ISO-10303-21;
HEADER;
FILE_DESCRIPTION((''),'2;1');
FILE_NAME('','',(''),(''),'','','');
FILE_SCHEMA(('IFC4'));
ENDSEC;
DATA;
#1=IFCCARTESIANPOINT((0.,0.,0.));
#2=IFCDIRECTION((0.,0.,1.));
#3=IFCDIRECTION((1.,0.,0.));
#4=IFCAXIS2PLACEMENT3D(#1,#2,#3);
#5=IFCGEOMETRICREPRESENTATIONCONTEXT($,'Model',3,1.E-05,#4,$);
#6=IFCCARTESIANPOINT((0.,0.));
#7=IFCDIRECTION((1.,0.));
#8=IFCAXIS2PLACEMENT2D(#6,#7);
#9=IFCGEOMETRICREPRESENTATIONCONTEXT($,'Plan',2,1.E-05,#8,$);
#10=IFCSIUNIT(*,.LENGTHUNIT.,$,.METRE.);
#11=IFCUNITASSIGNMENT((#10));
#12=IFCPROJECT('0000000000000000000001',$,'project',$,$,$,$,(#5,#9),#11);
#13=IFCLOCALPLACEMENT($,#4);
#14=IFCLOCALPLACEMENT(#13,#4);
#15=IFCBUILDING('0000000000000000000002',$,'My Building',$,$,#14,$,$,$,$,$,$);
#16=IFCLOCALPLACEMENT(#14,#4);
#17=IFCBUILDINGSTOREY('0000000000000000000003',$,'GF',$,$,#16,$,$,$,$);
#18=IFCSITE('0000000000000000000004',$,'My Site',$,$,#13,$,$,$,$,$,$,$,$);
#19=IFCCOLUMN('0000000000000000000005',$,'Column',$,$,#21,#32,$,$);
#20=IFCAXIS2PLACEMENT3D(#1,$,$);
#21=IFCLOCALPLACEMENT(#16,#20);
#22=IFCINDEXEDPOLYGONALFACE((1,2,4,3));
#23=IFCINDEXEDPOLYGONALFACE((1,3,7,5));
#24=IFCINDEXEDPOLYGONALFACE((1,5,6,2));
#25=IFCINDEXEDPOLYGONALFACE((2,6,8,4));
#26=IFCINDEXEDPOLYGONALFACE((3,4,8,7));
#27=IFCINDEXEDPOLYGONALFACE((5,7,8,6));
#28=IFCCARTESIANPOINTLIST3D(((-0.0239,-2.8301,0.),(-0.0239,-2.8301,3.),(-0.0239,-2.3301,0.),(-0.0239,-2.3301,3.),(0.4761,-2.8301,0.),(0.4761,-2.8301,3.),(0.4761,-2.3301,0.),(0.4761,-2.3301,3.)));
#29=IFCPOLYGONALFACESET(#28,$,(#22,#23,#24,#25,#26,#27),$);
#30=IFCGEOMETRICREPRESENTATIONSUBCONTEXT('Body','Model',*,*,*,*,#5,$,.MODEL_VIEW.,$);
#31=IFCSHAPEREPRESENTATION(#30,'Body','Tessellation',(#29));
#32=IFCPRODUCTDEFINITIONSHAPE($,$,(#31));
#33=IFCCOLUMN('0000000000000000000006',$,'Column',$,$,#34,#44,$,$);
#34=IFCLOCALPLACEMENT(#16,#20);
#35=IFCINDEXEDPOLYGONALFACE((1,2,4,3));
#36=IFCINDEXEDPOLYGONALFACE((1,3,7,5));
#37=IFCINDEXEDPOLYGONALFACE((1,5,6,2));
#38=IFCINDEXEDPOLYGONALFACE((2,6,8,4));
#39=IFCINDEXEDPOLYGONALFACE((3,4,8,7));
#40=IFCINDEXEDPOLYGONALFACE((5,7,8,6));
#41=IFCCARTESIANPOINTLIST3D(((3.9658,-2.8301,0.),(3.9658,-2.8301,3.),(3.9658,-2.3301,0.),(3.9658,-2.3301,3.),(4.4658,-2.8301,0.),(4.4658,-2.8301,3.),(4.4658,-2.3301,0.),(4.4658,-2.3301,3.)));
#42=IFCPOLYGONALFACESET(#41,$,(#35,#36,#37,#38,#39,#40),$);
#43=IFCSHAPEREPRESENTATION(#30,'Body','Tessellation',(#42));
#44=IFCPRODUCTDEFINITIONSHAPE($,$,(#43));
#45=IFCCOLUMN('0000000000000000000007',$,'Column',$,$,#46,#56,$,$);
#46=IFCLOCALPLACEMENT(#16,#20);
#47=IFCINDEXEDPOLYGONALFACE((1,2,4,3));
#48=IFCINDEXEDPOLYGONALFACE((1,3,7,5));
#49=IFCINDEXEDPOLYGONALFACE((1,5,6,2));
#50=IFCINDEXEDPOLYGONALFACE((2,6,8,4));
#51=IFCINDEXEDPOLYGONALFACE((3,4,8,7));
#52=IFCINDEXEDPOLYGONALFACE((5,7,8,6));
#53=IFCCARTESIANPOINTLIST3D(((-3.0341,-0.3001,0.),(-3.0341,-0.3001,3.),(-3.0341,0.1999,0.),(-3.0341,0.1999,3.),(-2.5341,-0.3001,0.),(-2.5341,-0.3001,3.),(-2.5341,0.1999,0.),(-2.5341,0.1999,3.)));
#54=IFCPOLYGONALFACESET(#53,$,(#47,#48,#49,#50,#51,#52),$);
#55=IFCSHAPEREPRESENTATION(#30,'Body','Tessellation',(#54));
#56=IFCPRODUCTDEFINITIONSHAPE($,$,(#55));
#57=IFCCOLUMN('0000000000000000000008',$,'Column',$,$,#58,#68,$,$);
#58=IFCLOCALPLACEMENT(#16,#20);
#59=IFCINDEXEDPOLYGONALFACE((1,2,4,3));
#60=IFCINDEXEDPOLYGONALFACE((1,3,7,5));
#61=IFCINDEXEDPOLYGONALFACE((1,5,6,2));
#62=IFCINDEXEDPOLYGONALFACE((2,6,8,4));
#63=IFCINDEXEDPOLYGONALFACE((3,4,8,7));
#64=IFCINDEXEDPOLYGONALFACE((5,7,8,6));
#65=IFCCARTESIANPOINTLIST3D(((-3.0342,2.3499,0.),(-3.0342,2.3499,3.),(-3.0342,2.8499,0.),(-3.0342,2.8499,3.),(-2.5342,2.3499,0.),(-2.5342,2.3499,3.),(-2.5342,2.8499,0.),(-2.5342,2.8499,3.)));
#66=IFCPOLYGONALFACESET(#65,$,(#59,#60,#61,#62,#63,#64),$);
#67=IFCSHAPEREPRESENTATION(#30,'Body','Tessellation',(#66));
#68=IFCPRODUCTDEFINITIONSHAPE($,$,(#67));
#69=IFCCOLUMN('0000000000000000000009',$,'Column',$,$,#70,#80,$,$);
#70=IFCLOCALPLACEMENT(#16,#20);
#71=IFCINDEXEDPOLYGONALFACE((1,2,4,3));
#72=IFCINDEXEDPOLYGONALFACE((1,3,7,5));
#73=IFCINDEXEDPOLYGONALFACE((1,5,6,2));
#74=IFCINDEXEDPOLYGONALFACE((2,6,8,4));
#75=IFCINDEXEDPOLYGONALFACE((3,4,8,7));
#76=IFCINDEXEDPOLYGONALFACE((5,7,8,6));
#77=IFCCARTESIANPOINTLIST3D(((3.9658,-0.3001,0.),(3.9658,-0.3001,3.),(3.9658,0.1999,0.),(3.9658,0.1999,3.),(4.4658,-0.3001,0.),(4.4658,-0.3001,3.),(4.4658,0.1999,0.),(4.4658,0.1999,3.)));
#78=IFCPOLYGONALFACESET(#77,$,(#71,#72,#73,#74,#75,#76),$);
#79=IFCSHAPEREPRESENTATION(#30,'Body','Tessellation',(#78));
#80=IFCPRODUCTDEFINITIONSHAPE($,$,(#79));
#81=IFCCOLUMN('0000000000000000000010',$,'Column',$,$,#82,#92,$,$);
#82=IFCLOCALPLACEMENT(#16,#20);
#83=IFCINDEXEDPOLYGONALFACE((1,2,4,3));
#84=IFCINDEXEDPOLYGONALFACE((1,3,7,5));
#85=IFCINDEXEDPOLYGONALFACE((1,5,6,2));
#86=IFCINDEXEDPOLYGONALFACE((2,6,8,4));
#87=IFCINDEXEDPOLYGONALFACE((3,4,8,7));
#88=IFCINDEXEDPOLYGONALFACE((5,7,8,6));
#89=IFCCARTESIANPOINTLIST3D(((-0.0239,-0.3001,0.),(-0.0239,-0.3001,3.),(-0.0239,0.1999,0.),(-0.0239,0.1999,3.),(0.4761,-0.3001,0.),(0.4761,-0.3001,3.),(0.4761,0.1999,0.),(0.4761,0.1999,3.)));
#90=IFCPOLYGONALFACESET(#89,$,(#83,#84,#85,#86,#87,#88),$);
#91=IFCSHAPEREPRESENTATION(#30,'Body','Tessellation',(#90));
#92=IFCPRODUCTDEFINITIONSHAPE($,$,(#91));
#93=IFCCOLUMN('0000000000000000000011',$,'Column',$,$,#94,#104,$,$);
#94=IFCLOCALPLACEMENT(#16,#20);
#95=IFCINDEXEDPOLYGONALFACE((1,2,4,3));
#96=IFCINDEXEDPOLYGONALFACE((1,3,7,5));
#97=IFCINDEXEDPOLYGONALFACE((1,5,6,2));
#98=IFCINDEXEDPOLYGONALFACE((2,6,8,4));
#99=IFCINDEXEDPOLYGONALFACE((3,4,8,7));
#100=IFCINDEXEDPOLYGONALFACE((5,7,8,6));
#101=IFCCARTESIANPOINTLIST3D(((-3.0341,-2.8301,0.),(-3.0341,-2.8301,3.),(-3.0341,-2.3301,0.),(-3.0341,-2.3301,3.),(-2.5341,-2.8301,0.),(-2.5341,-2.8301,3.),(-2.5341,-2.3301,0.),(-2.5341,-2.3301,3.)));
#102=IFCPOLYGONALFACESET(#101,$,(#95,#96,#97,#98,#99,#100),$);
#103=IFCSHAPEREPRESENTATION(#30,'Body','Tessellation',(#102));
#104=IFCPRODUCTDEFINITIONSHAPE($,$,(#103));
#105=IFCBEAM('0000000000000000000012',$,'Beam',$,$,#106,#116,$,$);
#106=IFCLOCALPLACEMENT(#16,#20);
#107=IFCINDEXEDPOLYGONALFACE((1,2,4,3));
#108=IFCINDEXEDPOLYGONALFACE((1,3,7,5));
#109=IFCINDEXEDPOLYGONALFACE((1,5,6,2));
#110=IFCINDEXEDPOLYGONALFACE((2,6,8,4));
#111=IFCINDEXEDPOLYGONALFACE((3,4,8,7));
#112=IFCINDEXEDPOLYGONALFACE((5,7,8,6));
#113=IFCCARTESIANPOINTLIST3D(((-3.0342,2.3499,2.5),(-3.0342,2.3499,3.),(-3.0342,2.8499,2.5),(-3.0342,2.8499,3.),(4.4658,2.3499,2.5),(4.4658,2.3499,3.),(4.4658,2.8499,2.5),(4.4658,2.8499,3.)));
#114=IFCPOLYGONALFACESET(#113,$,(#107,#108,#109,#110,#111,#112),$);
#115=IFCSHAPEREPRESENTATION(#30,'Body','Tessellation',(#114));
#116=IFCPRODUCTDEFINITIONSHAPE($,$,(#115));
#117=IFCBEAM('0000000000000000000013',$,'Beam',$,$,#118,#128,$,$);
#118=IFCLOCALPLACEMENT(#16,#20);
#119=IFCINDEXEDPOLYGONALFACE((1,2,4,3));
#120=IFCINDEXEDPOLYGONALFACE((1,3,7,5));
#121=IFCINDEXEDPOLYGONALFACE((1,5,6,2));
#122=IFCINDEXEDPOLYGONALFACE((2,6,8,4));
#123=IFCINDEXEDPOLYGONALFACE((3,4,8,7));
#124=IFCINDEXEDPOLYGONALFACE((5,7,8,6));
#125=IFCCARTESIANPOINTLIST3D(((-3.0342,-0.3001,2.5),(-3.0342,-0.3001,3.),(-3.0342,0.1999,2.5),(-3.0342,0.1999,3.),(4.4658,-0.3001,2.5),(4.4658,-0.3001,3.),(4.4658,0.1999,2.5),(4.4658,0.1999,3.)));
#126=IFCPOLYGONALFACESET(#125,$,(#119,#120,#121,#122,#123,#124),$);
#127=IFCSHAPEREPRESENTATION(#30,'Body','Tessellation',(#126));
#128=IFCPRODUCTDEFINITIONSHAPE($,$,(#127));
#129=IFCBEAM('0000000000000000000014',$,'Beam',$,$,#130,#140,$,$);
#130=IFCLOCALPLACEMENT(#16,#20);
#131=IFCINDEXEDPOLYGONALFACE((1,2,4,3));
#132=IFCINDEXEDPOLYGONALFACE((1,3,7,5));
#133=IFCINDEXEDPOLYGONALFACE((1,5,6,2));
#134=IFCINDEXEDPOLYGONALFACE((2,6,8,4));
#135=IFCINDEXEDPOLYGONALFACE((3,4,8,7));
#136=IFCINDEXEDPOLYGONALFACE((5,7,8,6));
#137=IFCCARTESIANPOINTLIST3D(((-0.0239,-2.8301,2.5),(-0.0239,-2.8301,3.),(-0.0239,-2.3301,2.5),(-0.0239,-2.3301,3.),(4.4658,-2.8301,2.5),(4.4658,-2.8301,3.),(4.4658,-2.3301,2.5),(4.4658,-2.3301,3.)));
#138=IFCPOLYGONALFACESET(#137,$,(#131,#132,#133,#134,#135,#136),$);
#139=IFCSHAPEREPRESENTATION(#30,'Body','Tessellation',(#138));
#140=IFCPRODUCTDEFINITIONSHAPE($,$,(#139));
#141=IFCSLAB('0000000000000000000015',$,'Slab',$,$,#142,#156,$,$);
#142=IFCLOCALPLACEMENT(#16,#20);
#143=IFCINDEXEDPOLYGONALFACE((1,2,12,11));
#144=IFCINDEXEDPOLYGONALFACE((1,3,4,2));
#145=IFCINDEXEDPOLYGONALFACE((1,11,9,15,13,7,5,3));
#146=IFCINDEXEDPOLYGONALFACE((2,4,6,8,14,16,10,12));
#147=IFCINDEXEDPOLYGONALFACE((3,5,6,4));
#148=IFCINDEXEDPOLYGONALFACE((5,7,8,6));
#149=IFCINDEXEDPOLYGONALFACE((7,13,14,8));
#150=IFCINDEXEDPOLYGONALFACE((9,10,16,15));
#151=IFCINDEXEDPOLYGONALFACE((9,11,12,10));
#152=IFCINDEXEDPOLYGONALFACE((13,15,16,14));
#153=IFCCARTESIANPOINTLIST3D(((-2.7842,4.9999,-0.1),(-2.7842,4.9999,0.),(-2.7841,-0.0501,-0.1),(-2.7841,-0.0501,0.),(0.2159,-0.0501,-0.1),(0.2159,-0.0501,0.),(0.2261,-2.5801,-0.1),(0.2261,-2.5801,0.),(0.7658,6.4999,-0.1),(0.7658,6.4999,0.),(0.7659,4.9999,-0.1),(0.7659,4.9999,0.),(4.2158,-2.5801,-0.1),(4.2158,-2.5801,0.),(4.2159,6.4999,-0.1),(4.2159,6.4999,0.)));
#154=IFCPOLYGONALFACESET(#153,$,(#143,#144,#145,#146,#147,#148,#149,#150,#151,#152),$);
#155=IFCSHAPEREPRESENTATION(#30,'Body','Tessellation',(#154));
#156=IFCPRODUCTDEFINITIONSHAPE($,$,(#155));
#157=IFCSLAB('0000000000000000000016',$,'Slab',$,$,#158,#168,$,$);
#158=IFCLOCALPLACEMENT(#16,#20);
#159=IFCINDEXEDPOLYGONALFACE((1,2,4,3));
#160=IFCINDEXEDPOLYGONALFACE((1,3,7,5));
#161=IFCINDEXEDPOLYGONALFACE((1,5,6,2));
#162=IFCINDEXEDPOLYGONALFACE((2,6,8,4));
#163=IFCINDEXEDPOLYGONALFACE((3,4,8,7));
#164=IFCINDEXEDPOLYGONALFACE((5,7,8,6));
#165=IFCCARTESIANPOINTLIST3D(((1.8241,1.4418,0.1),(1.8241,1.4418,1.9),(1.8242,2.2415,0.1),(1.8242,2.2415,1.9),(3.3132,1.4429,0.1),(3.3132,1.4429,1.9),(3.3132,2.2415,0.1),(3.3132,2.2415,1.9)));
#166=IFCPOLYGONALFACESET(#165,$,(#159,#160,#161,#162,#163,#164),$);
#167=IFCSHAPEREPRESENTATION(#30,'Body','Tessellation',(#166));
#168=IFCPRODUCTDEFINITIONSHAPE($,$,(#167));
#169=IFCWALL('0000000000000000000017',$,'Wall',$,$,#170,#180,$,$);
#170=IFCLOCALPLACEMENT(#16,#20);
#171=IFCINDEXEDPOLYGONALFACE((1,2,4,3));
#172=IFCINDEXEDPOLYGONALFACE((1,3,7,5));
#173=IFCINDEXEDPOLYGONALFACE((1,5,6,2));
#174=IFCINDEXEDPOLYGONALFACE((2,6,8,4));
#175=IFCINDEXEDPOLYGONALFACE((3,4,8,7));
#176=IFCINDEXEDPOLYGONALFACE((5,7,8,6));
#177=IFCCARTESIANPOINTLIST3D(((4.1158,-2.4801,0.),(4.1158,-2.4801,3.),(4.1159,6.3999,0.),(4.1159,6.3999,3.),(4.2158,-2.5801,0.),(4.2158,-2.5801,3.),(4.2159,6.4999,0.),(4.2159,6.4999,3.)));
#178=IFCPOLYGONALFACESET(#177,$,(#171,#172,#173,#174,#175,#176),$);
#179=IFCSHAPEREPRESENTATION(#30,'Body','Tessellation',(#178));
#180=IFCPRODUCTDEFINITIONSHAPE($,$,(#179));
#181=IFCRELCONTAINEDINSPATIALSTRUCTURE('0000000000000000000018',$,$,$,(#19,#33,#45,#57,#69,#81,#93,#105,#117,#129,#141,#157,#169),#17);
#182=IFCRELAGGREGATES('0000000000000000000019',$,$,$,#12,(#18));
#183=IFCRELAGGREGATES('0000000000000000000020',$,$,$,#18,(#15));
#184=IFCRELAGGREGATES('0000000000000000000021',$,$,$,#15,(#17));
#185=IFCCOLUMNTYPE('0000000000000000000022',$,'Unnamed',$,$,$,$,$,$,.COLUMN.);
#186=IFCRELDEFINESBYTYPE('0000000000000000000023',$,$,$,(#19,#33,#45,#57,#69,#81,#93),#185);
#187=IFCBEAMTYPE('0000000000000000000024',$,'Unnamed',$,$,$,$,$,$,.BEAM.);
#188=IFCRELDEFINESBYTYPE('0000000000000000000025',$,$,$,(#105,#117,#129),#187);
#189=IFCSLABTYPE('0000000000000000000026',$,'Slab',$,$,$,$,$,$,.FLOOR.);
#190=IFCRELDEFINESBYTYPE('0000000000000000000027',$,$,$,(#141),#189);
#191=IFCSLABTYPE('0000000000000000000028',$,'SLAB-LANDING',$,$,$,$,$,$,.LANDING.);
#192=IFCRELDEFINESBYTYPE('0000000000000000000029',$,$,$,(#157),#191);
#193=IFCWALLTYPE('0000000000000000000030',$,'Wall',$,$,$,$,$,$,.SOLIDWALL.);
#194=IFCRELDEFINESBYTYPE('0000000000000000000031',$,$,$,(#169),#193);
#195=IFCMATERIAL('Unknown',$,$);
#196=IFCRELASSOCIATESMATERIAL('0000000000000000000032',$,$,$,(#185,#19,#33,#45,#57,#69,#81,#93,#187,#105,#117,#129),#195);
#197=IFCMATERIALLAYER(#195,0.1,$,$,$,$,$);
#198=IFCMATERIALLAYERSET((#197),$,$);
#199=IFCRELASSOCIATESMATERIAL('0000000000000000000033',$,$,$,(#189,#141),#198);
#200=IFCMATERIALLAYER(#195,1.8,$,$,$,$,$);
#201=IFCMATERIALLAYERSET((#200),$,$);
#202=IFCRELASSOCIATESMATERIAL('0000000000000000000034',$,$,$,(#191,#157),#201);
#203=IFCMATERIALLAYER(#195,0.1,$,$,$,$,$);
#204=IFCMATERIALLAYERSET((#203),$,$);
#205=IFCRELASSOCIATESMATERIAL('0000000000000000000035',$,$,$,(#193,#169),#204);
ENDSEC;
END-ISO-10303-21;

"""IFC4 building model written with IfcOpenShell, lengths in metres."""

from ifc_helpers import new_model, si_unit, frame, origin_with_axes, origin_2d_with_axis, place, context, subcontext, project, spatial, line, indexed_curve, rectangle, outline, extrude, material, layer, layer_set, layer_usage, material_profile, profile_set, profile_usage, type_object, element, save


model = new_model("IFC4")

# Units and contexts
model_context = context("Model", 3, precision=1e-05, world=origin_with_axes())
plan_context = context("Plan", 2, precision=1e-05, world=origin_2d_with_axis())
body_context_1 = subcontext(model_context, "Body", "Model", "MODEL_VIEW")
ifc_project = project(units=[si_unit("LENGTHUNIT", "METRE")], contexts=[model_context, plan_context])

# Site, building, storey
site_placement = place(None, origin_with_axes())
site = spatial("IfcSite", under=ifc_project, at=site_placement, Name="My Site")
building_placement = place(site_placement, origin_with_axes())
building = spatial("IfcBuilding", under=site, at=building_placement, Name="My Building")
storey_placement = place(building_placement, origin_with_axes())
storey = spatial("IfcBuildingStorey", under=building, at=storey_placement, Name="GF")

# Columns
ifc_material = material(Name="Unknown")
ifc_material_profile_1 = material_profile(ifc_material, rectangle(XDim=0.5, YDim=0.5))
ifc_profile_set_1 = profile_set([ifc_material_profile_1])
ifc_profile_usage_1 = profile_usage(ifc_profile_set_1, cardinal=5)
column_type = type_object("IfcColumnType", Name="Unnamed", PredefinedType="COLUMN", material=ifc_profile_set_1)
column_1_placement = place(storey_placement, frame((0.2261, -2.5801, 0.0), z_axis=(0.0, 0.0, 1.0), x_axis=(1.0, 0.0, 0.0)))
element("IfcColumn", 1, at=column_1_placement, inside=storey, type_object=column_type, material=ifc_profile_usage_1, Name="Column", context=body_context_1, shape_type="SweptSolid", body=[
    extrude(rectangle(XDim=0.5, YDim=0.5), origin_with_axes(), (0.0, 0.0, 1.0), 3.0),
])
ifc_profile_usage_2 = profile_usage(ifc_profile_set_1, cardinal=5)
column_2_placement = place(storey_placement, frame((4.2158, -2.5801, 0.0), z_axis=(0.0, 0.0, 1.0), x_axis=(1.0, 0.0, 0.0)))
element("IfcColumn", 2, at=column_2_placement, inside=storey, type_object=column_type, material=ifc_profile_usage_2, Name="Column", context=body_context_1, shape_type="SweptSolid", body=[
    extrude(rectangle(XDim=0.5, YDim=0.5), origin_with_axes(), (0.0, 0.0, 1.0), 3.0),
])
ifc_profile_usage_3 = profile_usage(ifc_profile_set_1, cardinal=5)
column_3_placement = place(storey_placement, frame((-2.7841, -0.0501, 0.0), z_axis=(0.0, 0.0, 1.0), x_axis=(1.0, 0.0, 0.0)))
element("IfcColumn", 3, at=column_3_placement, inside=storey, type_object=column_type, material=ifc_profile_usage_3, Name="Column", context=body_context_1, shape_type="SweptSolid", body=[
    extrude(rectangle(XDim=0.5, YDim=0.5), origin_with_axes(), (0.0, 0.0, 1.0), 3.0),
])
ifc_profile_usage_4 = profile_usage(ifc_profile_set_1, cardinal=5)
column_4_placement = place(storey_placement, frame((-2.7842, 2.5999, 0.0), z_axis=(0.0, 0.0, 1.0), x_axis=(1.0, 0.0, 0.0)))
element("IfcColumn", 4, at=column_4_placement, inside=storey, type_object=column_type, material=ifc_profile_usage_4, Name="Column", context=body_context_1, shape_type="SweptSolid", body=[
    extrude(rectangle(XDim=0.5, YDim=0.5), origin_with_axes(), (0.0, 0.0, 1.0), 3.0),
])
ifc_profile_usage_5 = profile_usage(ifc_profile_set_1, cardinal=5)
column_5_placement = place(storey_placement, frame((4.2158, -0.0501, 0.0), z_axis=(0.0, 0.0, 1.0), x_axis=(1.0, 0.0, 0.0)))
element("IfcColumn", 5, at=column_5_placement, inside=storey, type_object=column_type, material=ifc_profile_usage_5, Name="Column", context=body_context_1, shape_type="SweptSolid", body=[
    extrude(rectangle(XDim=0.5, YDim=0.5), origin_with_axes(), (0.0, 0.0, 1.0), 3.0),
])
ifc_profile_usage_6 = profile_usage(ifc_profile_set_1, cardinal=5)
column_6_placement = place(storey_placement, frame((0.2261, -0.0501, 0.0), z_axis=(0.0, 0.0, 1.0), x_axis=(1.0, 0.0, 0.0)))
element("IfcColumn", 6, at=column_6_placement, inside=storey, type_object=column_type, material=ifc_profile_usage_6, Name="Column", context=body_context_1, shape_type="SweptSolid", body=[
    extrude(rectangle(XDim=0.5, YDim=0.5), origin_with_axes(), (0.0, 0.0, 1.0), 3.0),
])
ifc_profile_usage_7 = profile_usage(ifc_profile_set_1, cardinal=5)
column_7_placement = place(storey_placement, frame((-2.7841, -2.5801, 0.0), z_axis=(0.0, 0.0, 1.0), x_axis=(1.0, 0.0, 0.0)))
element("IfcColumn", 7, at=column_7_placement, inside=storey, type_object=column_type, material=ifc_profile_usage_7, Name="Column", context=body_context_1, shape_type="SweptSolid", body=[
    extrude(rectangle(XDim=0.5, YDim=0.5), origin_with_axes(), (0.0, 0.0, 1.0), 3.0),
])

# Beams
ifc_material_profile_2 = material_profile(ifc_material, rectangle(XDim=0.5, YDim=0.5))
ifc_profile_set_2 = profile_set([ifc_material_profile_2])
ifc_profile_usage_8 = profile_usage(ifc_profile_set_2, cardinal=7)
beam_type = type_object("IfcBeamType", Name="Unnamed", PredefinedType="BEAM", material=ifc_profile_set_2)
beam_1_placement = place(storey_placement, frame((4.4658, 2.3499, 3.0), z_axis=(-1.0, 0.0, 0.0), x_axis=(0.0, -1.0, 0.0)))
element("IfcBeam", 8, at=beam_1_placement, inside=storey, type_object=beam_type, material=ifc_profile_usage_8, Name="Beam", context=body_context_1, shape_type="SweptSolid", body=[
    extrude(rectangle(XDim=0.5, YDim=0.5), frame((-0.25, -0.25, 0.0), z_axis=(0.0, 0.0, 1.0), x_axis=(1.0, 0.0, 0.0)), (0.0, 0.0, 1.0), 7.5),
])
ifc_profile_usage_9 = profile_usage(ifc_profile_set_2, cardinal=7)
beam_2_placement = place(storey_placement, frame((4.4658, -0.3001, 3.0), z_axis=(-1.0, 0.0, 0.0), x_axis=(0.0, -1.0, 0.0)))
element("IfcBeam", 9, at=beam_2_placement, inside=storey, type_object=beam_type, material=ifc_profile_usage_9, Name="Beam", context=body_context_1, shape_type="SweptSolid", body=[
    extrude(rectangle(XDim=0.5, YDim=0.5), frame((-0.25, -0.25, 0.0), z_axis=(0.0, 0.0, 1.0), x_axis=(1.0, 0.0, 0.0)), (0.0, 0.0, 1.0), 7.5),
])
ifc_profile_usage_10 = profile_usage(ifc_profile_set_2, cardinal=7)
beam_3_placement = place(storey_placement, frame((4.4658, -2.8301, 3.0), z_axis=(-1.0, -0.000001, 0.0), x_axis=(0.000001, -1.0, 0.0)))
element("IfcBeam", 10, at=beam_3_placement, inside=storey, type_object=beam_type, material=ifc_profile_usage_10, Name="Beam", context=body_context_1, shape_type="SweptSolid", body=[
    extrude(rectangle(XDim=0.5, YDim=0.5), frame((-0.25, -0.25, 0.0), z_axis=(0.0, 0.0, 1.0), x_axis=(1.0, 0.0, 0.0)), (0.0, 0.0, 1.0), 4.4897),
])

# Slabs
ifc_layer_1 = layer(ifc_material, 0.1)
ifc_layer_set_1 = layer_set([ifc_layer_1])
ifc_layer_usage_1 = layer_usage(ifc_layer_set_1, "AXIS3", "POSITIVE", -0.1)
slab_type_1 = type_object("IfcSlabType", Name="Slab", PredefinedType="FLOOR", material=ifc_layer_set_1)
slab_1_placement = place(storey_placement, frame((0.2261, -2.5801, 0.0), z_axis=(0.0, 0.0, 1.0), x_axis=(1.0, 0.0, 0.0)))
element("IfcSlab", 11, at=slab_1_placement, inside=storey, type_object=slab_type_1, material=ifc_layer_usage_1, Name="Slab", context=body_context_1, shape_type="SweptSolid", body=[
    extrude(outline(indexed_curve([(0.0, 0.0), (3.9897, 0.0), (3.9897, 9.08), (0.5397, 9.08), (0.5397, 7.58), (-3.0103, 7.58), (-3.0103, 2.53), (-0.0103, 2.53), (0.0, 0.0)])), frame((0.0, 0.0, -0.1), z_axis=(0.0, 0.0, 1.0), x_axis=(1.0, 0.0, 0.0)), (0.0, 0.0, 1.0), 0.1),
])
ifc_layer_2 = layer(ifc_material, 1.8)
ifc_layer_set_2 = layer_set([ifc_layer_2])
slab_type_2 = type_object("IfcSlabType", Name="SLAB-LANDING", PredefinedType="LANDING", material=ifc_layer_set_2)
ifc_layer_usage_2 = layer_usage(ifc_layer_set_2, "AXIS3", "POSITIVE", -1.8)
slab_2_placement = place(storey_placement, frame((1.8241, 1.4418, 1.9), z_axis=(0.0, 0.0, 1.0), x_axis=(1.0, 0.0, 0.0)))
element("IfcSlab", 12, at=slab_2_placement, inside=storey, type_object=slab_type_2, material=ifc_layer_usage_2, Name="Slab", context=body_context_1, shape_type="SweptSolid", body=[
    extrude(outline(indexed_curve([(0.0, 0.0), (1.489, 0.0011), (1.489, 0.7997), (0.0, 0.7997), (0.0, 0.0)])), frame((0.0, 0.0, -1.8), z_axis=(0.0, 0.0, 1.0), x_axis=(1.0, 0.0, 0.0)), (0.0, 0.0, 1.0), 1.8),
])

# Shared definitions
ifc_layer_3 = layer(ifc_material, 0.1)
ifc_layer_set_3 = layer_set([ifc_layer_3])
wall_type = type_object("IfcWallType", Name="Wall", PredefinedType="SOLIDWALL", material=ifc_layer_set_3)

# Wall
ifc_layer_usage_3 = layer_usage(ifc_layer_set_3, "AXIS2", "POSITIVE", 0.0)
wall_1_placement = place(storey_placement, frame((4.2158, -2.5801, 0.0), z_axis=(0.0, 0.0, 1.0), x_axis=(0.0, 1.0, 0.0)))
element("IfcWall", 13, at=wall_1_placement, inside=storey, type_object=wall_type, material=ifc_layer_usage_3, Name="Wall", context=body_context_1, shape_type="SweptSolid", body=[
    extrude(outline(indexed_curve([(0.0, 0.0), (0.1, 0.1), (8.98, 0.1), (9.08, 0.0)], segments=[line(1, 2, 3, 4, 1)])), origin_with_axes(), (0.0, 0.0, 1.0), 3.0),
])

save(model, "model.ifc")
